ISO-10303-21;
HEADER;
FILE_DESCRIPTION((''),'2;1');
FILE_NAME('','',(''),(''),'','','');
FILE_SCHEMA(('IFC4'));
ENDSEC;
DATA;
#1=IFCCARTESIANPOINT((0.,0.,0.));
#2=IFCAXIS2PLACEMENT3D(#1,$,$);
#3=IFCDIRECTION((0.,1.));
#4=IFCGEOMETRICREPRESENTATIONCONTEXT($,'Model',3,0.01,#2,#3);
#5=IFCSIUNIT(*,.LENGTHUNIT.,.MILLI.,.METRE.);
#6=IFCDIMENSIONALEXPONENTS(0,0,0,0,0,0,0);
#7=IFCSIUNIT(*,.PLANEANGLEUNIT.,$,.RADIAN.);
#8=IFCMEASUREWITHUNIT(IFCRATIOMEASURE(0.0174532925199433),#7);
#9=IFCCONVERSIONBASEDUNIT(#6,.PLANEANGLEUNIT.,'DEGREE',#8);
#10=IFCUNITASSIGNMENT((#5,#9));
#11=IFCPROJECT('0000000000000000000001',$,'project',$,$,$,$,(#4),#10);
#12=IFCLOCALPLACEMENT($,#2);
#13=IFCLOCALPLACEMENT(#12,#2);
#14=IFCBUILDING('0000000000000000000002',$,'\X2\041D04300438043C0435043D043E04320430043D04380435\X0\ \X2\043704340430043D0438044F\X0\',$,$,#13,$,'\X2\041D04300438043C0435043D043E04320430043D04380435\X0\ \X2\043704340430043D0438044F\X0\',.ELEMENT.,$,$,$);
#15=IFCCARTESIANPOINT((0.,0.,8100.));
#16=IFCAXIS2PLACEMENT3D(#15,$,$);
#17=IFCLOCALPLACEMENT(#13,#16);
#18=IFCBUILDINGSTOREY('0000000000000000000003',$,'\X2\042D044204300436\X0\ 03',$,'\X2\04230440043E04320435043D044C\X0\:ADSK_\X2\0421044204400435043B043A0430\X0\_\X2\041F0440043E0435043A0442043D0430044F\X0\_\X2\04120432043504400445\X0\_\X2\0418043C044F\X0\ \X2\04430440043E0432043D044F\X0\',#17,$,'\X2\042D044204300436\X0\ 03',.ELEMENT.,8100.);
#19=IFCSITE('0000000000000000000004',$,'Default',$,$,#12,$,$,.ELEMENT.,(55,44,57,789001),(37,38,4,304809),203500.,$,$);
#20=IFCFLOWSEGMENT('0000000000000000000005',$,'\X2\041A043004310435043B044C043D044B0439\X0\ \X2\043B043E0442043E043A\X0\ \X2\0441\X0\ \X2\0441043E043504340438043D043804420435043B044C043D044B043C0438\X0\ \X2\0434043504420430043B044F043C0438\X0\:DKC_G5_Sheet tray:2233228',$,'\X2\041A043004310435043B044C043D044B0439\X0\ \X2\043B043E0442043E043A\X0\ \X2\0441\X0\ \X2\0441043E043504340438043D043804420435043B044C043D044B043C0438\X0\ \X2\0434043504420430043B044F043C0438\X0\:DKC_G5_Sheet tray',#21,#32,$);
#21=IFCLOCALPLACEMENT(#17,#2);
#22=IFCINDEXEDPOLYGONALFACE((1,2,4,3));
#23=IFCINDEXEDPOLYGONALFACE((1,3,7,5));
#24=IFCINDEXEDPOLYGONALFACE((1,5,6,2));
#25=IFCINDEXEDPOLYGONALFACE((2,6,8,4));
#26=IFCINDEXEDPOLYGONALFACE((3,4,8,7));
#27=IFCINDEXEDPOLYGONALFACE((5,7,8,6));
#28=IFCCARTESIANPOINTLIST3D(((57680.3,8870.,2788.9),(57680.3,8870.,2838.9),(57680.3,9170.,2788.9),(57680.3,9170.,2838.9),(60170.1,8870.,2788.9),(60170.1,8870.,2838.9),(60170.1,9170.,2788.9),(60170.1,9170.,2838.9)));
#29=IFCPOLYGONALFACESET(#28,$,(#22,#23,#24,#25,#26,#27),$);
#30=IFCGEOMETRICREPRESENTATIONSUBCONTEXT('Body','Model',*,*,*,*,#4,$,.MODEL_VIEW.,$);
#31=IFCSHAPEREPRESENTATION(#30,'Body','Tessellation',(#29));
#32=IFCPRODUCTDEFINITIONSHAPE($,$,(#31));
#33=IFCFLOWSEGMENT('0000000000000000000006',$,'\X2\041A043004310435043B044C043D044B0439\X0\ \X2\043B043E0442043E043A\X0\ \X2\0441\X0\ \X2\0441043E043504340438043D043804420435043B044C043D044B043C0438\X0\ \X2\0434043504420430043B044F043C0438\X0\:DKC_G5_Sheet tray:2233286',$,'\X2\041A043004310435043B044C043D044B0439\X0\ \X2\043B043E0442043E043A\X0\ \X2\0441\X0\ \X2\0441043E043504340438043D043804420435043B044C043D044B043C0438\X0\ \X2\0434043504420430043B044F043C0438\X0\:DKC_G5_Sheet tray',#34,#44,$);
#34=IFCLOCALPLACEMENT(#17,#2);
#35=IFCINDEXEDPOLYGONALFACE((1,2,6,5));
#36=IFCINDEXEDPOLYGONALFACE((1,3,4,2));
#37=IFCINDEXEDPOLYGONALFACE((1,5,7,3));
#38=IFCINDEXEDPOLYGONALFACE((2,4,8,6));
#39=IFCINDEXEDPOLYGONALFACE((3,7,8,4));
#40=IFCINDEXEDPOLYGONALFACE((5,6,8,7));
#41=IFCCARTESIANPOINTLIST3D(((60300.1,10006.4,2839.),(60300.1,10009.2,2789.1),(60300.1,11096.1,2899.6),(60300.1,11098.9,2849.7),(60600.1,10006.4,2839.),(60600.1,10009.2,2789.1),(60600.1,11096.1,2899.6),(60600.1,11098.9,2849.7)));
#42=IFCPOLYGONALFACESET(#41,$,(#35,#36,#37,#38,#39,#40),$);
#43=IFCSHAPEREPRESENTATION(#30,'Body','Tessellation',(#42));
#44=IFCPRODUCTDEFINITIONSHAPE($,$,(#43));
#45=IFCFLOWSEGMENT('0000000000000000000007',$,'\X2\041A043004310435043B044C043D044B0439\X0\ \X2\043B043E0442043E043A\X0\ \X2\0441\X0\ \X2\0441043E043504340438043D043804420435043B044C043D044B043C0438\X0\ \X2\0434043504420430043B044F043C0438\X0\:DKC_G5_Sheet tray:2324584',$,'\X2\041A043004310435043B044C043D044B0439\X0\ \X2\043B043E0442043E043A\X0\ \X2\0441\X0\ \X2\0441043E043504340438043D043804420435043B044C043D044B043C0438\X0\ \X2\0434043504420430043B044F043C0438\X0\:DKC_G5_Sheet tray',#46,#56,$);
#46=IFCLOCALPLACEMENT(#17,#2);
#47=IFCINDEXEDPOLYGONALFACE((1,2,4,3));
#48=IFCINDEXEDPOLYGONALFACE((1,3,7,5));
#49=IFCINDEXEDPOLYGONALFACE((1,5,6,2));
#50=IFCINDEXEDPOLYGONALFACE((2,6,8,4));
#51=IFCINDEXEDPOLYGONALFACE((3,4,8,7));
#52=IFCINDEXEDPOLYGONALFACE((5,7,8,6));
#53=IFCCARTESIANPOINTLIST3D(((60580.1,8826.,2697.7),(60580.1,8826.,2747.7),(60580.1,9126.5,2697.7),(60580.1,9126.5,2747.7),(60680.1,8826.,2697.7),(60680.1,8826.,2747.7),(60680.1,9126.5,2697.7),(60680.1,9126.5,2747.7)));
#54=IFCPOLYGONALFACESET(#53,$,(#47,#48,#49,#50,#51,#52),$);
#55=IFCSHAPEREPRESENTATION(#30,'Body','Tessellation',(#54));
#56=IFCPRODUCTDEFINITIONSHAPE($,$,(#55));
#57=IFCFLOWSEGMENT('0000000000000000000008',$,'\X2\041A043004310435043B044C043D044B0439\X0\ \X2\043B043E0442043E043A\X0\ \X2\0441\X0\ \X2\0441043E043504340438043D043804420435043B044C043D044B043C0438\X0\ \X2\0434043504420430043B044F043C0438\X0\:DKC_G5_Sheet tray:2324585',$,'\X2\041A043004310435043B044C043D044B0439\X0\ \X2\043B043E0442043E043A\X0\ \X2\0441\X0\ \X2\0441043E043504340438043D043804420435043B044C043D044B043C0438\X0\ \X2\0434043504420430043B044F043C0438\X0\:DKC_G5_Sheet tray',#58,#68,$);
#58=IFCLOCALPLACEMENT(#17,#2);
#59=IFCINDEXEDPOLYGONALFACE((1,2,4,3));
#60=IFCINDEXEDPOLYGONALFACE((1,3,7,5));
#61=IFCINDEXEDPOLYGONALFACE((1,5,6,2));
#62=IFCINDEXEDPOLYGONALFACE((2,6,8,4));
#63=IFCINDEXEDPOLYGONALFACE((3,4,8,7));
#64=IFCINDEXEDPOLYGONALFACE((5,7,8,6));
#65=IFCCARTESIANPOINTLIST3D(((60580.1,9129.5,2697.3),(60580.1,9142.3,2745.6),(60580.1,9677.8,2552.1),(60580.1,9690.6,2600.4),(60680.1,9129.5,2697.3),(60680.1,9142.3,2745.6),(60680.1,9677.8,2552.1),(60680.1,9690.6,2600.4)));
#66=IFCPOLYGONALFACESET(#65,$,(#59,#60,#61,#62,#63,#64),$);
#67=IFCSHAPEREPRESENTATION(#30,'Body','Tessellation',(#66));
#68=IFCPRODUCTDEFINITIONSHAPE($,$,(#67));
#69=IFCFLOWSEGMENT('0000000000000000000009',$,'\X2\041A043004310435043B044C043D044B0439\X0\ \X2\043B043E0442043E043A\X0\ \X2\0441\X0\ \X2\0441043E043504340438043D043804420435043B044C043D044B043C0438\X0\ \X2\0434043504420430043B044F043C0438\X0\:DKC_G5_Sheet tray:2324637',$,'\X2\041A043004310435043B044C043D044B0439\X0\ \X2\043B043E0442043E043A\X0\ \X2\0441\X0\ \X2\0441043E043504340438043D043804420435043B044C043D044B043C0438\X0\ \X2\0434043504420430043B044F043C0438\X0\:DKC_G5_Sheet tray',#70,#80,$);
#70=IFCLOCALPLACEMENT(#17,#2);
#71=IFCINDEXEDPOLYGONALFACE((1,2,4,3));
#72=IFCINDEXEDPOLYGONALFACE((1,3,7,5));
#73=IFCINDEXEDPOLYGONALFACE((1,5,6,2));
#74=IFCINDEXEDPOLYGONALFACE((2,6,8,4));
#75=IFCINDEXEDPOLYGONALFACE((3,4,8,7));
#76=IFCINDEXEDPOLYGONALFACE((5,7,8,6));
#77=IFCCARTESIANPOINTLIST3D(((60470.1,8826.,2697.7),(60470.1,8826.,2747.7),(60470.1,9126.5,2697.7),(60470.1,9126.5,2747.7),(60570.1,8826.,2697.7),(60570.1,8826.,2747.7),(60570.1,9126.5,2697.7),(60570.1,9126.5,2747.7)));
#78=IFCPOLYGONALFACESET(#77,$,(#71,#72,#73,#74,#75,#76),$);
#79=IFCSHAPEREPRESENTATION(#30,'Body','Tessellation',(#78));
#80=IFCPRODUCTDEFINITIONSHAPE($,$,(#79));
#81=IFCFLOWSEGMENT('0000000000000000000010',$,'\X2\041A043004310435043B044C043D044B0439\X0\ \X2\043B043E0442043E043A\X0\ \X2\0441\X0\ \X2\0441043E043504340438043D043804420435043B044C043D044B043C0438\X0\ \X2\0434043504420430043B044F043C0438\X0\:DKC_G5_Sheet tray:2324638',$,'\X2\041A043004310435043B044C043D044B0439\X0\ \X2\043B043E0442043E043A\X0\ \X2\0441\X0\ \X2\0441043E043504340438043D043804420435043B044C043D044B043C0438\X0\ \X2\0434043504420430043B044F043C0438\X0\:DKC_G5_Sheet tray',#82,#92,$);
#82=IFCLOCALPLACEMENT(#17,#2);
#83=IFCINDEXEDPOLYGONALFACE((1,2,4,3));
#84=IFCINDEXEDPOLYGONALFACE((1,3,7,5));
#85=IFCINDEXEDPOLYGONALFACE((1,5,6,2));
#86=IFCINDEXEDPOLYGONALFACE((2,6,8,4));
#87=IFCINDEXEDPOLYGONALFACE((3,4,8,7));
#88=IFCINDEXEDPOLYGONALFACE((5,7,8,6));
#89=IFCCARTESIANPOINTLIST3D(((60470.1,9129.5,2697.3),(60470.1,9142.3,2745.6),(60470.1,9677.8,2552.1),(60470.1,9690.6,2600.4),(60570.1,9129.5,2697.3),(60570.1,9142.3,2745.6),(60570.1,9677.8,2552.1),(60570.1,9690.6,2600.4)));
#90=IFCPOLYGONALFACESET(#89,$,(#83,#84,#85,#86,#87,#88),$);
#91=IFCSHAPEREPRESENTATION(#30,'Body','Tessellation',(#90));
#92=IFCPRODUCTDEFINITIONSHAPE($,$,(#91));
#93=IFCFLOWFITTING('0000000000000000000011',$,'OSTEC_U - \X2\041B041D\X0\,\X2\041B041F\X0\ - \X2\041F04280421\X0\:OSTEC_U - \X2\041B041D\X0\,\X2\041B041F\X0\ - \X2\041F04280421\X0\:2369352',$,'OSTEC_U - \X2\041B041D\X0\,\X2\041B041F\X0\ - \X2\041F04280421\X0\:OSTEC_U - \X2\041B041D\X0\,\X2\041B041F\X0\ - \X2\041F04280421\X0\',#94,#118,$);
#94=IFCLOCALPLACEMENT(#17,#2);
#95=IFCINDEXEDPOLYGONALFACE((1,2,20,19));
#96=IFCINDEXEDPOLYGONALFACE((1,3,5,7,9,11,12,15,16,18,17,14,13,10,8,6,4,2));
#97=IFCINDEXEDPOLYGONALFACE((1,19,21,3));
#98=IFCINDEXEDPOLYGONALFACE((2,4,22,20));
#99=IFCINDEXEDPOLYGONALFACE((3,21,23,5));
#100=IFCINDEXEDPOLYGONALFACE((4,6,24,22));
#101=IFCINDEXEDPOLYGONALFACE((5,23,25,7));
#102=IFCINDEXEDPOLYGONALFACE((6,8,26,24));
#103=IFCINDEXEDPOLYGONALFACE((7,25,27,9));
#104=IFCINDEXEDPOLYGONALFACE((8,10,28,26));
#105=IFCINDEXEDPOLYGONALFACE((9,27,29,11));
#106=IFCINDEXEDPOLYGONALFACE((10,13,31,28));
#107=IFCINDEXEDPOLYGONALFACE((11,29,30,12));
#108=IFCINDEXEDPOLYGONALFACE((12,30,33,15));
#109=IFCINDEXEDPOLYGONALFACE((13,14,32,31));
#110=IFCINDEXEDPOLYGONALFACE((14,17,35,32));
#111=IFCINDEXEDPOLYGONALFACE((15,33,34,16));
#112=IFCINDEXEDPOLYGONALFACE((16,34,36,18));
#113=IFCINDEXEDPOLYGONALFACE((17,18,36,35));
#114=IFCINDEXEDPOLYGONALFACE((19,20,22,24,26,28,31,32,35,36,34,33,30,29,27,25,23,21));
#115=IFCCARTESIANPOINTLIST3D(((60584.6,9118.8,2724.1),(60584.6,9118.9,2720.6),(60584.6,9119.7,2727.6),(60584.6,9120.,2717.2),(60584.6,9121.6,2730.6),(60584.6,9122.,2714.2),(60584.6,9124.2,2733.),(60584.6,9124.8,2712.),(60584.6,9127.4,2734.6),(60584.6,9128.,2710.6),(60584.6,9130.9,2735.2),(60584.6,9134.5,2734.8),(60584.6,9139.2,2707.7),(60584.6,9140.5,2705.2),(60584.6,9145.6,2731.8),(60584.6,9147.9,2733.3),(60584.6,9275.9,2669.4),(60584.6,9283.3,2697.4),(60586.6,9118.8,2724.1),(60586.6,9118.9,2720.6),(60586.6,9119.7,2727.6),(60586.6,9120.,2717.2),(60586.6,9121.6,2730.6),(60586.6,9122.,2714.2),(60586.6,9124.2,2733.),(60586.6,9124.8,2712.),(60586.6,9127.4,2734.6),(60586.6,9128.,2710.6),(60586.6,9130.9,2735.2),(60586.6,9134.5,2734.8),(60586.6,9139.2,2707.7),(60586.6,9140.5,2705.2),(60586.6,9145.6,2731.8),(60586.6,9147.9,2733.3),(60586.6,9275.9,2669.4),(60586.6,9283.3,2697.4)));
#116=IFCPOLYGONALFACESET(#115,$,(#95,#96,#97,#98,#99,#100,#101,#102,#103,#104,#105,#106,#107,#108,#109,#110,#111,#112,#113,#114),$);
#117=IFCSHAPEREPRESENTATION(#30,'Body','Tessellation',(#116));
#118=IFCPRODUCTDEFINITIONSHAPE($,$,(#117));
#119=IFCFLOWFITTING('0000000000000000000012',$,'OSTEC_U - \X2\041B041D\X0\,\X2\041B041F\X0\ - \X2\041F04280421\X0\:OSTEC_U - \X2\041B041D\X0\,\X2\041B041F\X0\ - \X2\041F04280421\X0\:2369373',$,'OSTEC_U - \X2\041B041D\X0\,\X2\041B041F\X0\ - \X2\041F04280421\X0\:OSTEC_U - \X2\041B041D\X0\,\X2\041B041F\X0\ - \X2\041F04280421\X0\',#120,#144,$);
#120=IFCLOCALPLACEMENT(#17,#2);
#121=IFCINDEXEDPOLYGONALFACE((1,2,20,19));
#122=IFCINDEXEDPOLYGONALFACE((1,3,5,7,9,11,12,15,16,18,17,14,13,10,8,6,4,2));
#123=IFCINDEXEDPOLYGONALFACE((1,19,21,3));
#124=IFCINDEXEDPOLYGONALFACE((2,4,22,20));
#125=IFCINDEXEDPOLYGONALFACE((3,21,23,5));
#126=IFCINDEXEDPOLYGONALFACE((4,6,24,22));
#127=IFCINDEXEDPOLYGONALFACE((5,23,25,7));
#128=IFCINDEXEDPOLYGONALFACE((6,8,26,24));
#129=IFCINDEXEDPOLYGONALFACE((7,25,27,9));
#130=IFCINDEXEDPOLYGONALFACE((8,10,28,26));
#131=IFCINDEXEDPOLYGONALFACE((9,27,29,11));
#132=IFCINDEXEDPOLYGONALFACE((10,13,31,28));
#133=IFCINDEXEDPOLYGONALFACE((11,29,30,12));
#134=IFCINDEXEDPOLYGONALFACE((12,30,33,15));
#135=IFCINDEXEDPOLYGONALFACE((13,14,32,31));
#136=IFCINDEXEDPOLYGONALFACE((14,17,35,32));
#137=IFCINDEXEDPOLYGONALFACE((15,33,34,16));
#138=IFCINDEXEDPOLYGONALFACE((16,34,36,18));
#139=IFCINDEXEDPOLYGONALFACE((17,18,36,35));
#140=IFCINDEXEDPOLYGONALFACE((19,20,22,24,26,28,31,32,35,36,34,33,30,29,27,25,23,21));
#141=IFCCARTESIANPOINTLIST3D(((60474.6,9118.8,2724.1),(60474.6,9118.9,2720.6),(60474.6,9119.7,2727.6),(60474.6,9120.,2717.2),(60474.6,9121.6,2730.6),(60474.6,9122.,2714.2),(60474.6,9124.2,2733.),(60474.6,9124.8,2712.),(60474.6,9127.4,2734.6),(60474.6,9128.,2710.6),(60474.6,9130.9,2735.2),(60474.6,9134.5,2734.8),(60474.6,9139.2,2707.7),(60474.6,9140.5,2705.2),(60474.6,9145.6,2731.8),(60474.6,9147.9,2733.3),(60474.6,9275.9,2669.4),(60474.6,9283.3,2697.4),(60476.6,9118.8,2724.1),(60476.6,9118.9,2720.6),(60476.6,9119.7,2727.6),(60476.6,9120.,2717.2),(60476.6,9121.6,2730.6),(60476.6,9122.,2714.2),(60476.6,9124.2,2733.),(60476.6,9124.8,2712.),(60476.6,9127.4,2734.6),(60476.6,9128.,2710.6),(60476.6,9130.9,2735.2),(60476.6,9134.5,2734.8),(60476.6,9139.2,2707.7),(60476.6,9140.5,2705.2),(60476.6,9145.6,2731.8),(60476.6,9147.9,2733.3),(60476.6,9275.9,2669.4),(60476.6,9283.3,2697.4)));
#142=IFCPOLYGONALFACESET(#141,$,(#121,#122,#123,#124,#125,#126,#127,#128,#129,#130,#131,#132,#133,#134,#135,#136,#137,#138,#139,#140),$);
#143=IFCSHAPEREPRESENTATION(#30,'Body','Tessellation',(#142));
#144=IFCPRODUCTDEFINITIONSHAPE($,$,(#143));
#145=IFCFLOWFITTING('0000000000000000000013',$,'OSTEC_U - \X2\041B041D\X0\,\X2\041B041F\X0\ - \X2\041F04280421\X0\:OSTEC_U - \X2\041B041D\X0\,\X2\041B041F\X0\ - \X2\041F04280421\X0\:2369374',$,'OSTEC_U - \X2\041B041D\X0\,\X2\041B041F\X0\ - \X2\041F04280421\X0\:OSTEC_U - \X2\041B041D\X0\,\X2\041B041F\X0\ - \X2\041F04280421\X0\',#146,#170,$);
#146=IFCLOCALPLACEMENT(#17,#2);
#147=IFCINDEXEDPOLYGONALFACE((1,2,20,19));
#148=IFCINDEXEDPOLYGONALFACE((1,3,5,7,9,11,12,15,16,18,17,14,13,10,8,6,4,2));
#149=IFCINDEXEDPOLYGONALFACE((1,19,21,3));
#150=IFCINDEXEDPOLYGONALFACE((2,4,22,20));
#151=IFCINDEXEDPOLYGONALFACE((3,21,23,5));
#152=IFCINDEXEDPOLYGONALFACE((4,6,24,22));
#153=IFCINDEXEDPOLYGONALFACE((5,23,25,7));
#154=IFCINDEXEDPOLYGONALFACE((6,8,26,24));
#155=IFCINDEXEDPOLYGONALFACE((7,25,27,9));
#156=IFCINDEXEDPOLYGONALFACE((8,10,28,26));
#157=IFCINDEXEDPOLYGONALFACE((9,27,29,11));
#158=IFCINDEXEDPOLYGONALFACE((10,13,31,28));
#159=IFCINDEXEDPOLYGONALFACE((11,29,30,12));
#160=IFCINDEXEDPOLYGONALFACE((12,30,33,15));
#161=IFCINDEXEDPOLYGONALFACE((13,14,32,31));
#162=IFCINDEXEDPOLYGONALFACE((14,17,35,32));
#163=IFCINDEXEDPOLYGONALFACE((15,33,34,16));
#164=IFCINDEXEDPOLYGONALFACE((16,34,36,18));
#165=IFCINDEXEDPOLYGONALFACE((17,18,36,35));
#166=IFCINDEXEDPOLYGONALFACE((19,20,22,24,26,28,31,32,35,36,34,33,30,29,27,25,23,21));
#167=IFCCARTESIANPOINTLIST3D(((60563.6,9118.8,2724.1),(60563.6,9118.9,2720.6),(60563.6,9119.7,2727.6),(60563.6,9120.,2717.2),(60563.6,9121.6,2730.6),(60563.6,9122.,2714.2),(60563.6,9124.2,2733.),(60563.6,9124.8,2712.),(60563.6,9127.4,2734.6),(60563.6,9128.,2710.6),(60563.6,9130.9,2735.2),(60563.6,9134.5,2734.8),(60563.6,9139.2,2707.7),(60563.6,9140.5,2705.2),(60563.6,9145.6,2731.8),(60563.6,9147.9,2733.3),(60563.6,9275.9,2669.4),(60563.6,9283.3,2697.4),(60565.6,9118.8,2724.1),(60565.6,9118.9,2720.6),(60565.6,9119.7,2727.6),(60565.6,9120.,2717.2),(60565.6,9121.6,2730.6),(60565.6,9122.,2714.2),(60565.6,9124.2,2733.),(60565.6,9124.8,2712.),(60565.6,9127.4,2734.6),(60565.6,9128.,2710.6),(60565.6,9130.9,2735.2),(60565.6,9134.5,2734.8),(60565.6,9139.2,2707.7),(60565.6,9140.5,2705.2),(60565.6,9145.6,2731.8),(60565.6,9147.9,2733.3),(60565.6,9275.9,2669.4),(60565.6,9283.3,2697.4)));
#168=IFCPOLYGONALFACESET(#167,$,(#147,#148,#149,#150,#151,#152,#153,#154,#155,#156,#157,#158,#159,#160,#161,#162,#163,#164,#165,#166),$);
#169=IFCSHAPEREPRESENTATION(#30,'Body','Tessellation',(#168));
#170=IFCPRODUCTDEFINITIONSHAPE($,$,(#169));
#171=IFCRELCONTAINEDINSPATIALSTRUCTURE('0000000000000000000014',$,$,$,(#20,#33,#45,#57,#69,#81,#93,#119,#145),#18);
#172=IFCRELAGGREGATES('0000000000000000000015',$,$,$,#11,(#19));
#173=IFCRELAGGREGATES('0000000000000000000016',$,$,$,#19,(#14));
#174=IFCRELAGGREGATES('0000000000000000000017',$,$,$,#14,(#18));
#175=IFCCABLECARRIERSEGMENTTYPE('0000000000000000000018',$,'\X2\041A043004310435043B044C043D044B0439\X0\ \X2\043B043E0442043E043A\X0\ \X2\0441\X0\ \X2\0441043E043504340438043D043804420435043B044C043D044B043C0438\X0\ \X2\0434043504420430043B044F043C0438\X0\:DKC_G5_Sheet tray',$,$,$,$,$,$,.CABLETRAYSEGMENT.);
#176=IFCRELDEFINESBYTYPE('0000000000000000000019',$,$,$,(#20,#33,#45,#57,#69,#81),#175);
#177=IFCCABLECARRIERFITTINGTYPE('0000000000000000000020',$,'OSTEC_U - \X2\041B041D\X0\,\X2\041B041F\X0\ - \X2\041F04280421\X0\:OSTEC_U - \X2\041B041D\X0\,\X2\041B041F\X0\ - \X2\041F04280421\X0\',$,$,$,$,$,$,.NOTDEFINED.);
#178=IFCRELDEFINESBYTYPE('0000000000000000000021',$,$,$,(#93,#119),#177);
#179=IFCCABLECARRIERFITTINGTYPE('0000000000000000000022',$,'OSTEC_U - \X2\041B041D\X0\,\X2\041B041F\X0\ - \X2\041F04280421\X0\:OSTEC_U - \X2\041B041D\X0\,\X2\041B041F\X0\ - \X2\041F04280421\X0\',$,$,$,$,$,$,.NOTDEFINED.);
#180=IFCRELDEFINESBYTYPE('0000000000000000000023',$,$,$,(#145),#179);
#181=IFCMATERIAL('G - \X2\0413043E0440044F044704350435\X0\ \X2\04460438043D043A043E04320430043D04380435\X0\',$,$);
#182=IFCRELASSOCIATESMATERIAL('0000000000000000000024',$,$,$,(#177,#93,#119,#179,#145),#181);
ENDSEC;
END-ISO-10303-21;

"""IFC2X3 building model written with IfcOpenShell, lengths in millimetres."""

from ifc_helpers import new_model, entity, si_unit, converted_unit, direction, frame, frame_2d, origin, origin_2d_with_axis, place, context, subcontext, project, spatial, polyline, circle_curve, parameter, trimmed, segment, composite_curve, rectangle, outline, extrude, source, transform, mapped, material, type_object, type_shapes, element, save


model = new_model("IFC2X3")

# Units and contexts
model_context = context("Model", 3, precision=0.01, world=origin(), true_north=direction((0.0, 1.0)))
body_context = subcontext(model_context, "Body", "Model", "MODEL_VIEW")
ifc_project = project(units=[si_unit("LENGTHUNIT", "METRE", prefix="MILLI"), converted_unit("PLANEANGLEUNIT", "DEGREE", entity("IfcRatioMeasure", 0.0174532925199433), si_unit("PLANEANGLEUNIT", "RADIAN"), dimensions=[0, 0, 0, 0, 0, 0, 0])], contexts=[model_context])

# Site, building, storey
site_placement = place(None, origin())
site = spatial("IfcSite", under=ifc_project, at=site_placement, Name="Default", CompositionType="ELEMENT", RefLatitude=(55, 44, 57, 789001), RefLongitude=(37, 38, 4, 304809), RefElevation=203500.0)
building_placement = place(site_placement, origin())
building = spatial("IfcBuilding", under=site, at=building_placement, Name="Наименование здания", LongName="Наименование здания", CompositionType="ELEMENT")
storey_placement = place(building_placement, frame((0.0, 0.0, 8100.0)))
storey = spatial("IfcBuildingStorey", under=building, at=storey_placement, Name="Этаж 03", ObjectType="Уровень:ADSK_Стрелка_Проектная_Вверх_Имя уровня", LongName="Этаж 03", CompositionType="ELEMENT", Elevation=8100.0)

# Flow segments
cable_carrier_segment_type = type_object("IfcCableCarrierSegmentType", Name="Кабельный лоток с соединительными деталями:DKC_G5_Sheet tray", PredefinedType="CABLETRAYSEGMENT")
flow_segment_1_placement = place(storey_placement, frame((57680.2, 8870.0, 2788.9)))
element("IfcFlowSegment", 1, at=flow_segment_1_placement, inside=storey, type_object=cable_carrier_segment_type, Name="Кабельный лоток с соединительными деталями:DKC_G5_Sheet tray:2233228", ObjectType="Кабельный лоток с соединительными деталями:DKC_G5_Sheet tray", context=body_context, shape_type="SweptSolid", body=[
    extrude(rectangle(XDim=2489.9, YDim=300.0, at=origin_2d_with_axis()), frame((1244.9, 150.0, 0.0)), (0.0, 0.0, 1.0), 50.0),
])
flow_segment_2_placement = place(storey_placement, frame((60300.1, 10006.4, 2789.1)))
element("IfcFlowSegment", 2, at=flow_segment_2_placement, inside=storey, type_object=cable_carrier_segment_type, Name="Кабельный лоток с соединительными деталями:DKC_G5_Sheet tray:2233286", ObjectType="Кабельный лоток с соединительными деталями:DKC_G5_Sheet tray", context=body_context, shape_type="SweptSolid", body=[
    extrude(rectangle(XDim=50.0, YDim=1091.4, at=frame_2d((0.0, 0.0), x_axis=(0.0, 1.0))), frame((0.0, 546.2, 55.3), z_axis=(1.0, 0.0, 0.0), x_axis=(0.0, -0.998458, -0.055513)), (0.0, 0.0, 1.0), 300.0),
])
flow_segment_3_placement = place(storey_placement, frame((60580.1, 8826.0, 2697.7)))
element("IfcFlowSegment", 3, at=flow_segment_3_placement, inside=storey, type_object=cable_carrier_segment_type, Name="Кабельный лоток с соединительными деталями:DKC_G5_Sheet tray:2324584", ObjectType="Кабельный лоток с соединительными деталями:DKC_G5_Sheet tray", context=body_context, shape_type="SweptSolid", body=[
    extrude(rectangle(XDim=300.4, YDim=100.0, at=origin_2d_with_axis()), frame((50.0, 150.2, 0.0), z_axis=(0.0, 0.0, 1.0), x_axis=(0.0, -1.0, 0.0)), (0.0, 0.0, 1.0), 50.0),
])
flow_segment_4_placement = place(storey_placement, frame((60580.1, 9129.5, 2552.1)))
element("IfcFlowSegment", 4, at=flow_segment_4_placement, inside=storey, type_object=cable_carrier_segment_type, Name="Кабельный лоток с соединительными деталями:DKC_G5_Sheet tray:2324585", ObjectType="Кабельный лоток с соединительными деталями:DKC_G5_Sheet tray", context=body_context, shape_type="SweptSolid", body=[
    extrude(rectangle(XDim=50.0, YDim=567.3, at=frame_2d((0.0, 0.0), x_axis=(0.0, 1.0))), frame((0.0, 280.6, 96.8), z_axis=(1.0, 0.0, 0.0), x_axis=(0.0, 0.966668, -0.256034)), (0.0, 0.0, 1.0), 100.0),
])
flow_segment_5_placement = place(storey_placement, frame((60470.1, 8826.0, 2697.7)))
element("IfcFlowSegment", 5, at=flow_segment_5_placement, inside=storey, type_object=cable_carrier_segment_type, Name="Кабельный лоток с соединительными деталями:DKC_G5_Sheet tray:2324637", ObjectType="Кабельный лоток с соединительными деталями:DKC_G5_Sheet tray", context=body_context, shape_type="SweptSolid", body=[
    extrude(rectangle(XDim=300.4, YDim=100.0, at=origin_2d_with_axis()), frame((50.0, 150.2, 0.0), z_axis=(0.0, 0.0, 1.0), x_axis=(0.0, -1.0, 0.0)), (0.0, 0.0, 1.0), 50.0),
])
flow_segment_6_placement = place(storey_placement, frame((60470.1, 9129.5, 2552.1)))
element("IfcFlowSegment", 6, at=flow_segment_6_placement, inside=storey, type_object=cable_carrier_segment_type, Name="Кабельный лоток с соединительными деталями:DKC_G5_Sheet tray:2324638", ObjectType="Кабельный лоток с соединительными деталями:DKC_G5_Sheet tray", context=body_context, shape_type="SweptSolid", body=[
    extrude(rectangle(XDim=50.0, YDim=567.3, at=frame_2d((0.0, 0.0), x_axis=(0.0, 1.0))), frame((0.0, 280.6, 96.8), z_axis=(1.0, 0.0, 0.0), x_axis=(0.0, 0.966668, -0.256034)), (0.0, 0.0, 1.0), 100.0),
])

# Flow fittings
ifc_material = material(Name="G - Горячее цинкование")
cable_carrier_fitting_type_1 = type_object("IfcCableCarrierFittingType", Name="OSTEC_U - ЛН,ЛП - ПШС:OSTEC_U - ЛН,ЛП - ПШС", PredefinedType="NOTDEFINED", material=ifc_material)
shared_shape_1 = source(origin(), body_context, "Body", "SweptSolid", [
    extrude(outline(composite_curve([segment(trimmed(circle_curve(frame_2d((-44.6, 0.0), x_axis=(1.0, 0.0)), 12.5), [parameter(90.0)], [parameter(270.0)], True, "PARAMETER"), True, "CONTINUOUS"), segment(polyline([(-44.6, -12.5), (-33.1, -12.5)]), True, "CONTINUOUS"), segment(polyline([(-33.1, -12.5), (-31.2, -14.5)]), True, "CONTINUOUS"), segment(polyline([(-31.2, -14.5), (108.9, -14.5)]), True, "CONTINUOUS"), segment(polyline([(108.9, -14.5), (108.9, 14.5)]), True, "CONTINUOUS"), segment(polyline([(108.9, 14.5), (-31.2, 14.5)]), True, "CONTINUOUS"), segment(polyline([(-31.2, 14.5), (-33.1, 12.5)]), True, "CONTINUOUS"), segment(polyline([(-33.1, 12.5), (-44.6, 12.5)]), True, "CONTINUOUS")], self_intersect=False)), frame((44.6, 0.0, 0.0), z_axis=(0.0, 0.0, -1.0), x_axis=(1.0, 0.0, 0.0)), (0.0, 0.0, -1.0), 2.0),
])
type_shapes(cable_carrier_fitting_type_1, [shared_shape_1])
flow_fitting_1_placement = place(storey_placement, frame((60586.7, 9131.2, 2722.7), z_axis=(-1.0, 0.0, 0.0), x_axis=(0.0, 0.966668, -0.256034)))
element("IfcFlowFitting", 7, at=flow_fitting_1_placement, inside=storey, type_object=cable_carrier_fitting_type_1, material=ifc_material, Name="OSTEC_U - ЛН,ЛП - ПШС:OSTEC_U - ЛН,ЛП - ПШС:2369352", ObjectType="OSTEC_U - ЛН,ЛП - ПШС:OSTEC_U - ЛН,ЛП - ПШС", context=body_context, shape_type="MappedRepresentation", body=[
    mapped(shared_shape_1, transform((0.0, 0.0, 0.0), scale=1.0)),
])
flow_fitting_2_placement = place(storey_placement, frame((60476.7, 9131.2, 2722.7), z_axis=(-1.0, 0.0, 0.0), x_axis=(0.0, 0.966668, -0.256034)))
element("IfcFlowFitting", 8, at=flow_fitting_2_placement, inside=storey, type_object=cable_carrier_fitting_type_1, material=ifc_material, Name="OSTEC_U - ЛН,ЛП - ПШС:OSTEC_U - ЛН,ЛП - ПШС:2369373", ObjectType="OSTEC_U - ЛН,ЛП - ПШС:OSTEC_U - ЛН,ЛП - ПШС", context=body_context, shape_type="MappedRepresentation", body=[
    mapped(shared_shape_1, transform((0.0, 0.0, 0.0), scale=1.0)),
])
shared_shape_2 = source(origin(), body_context, "Body", "SweptSolid", [
    extrude(outline(composite_curve([segment(trimmed(circle_curve(frame_2d((-44.6, 0.0), x_axis=(1.0, 0.0)), 12.5), [parameter(90.0)], [parameter(270.0)], True, "PARAMETER"), True, "CONTINUOUS"), segment(polyline([(-44.6, -12.5), (-33.1, -12.5)]), True, "CONTINUOUS"), segment(polyline([(-33.1, -12.5), (-31.2, -14.5)]), True, "CONTINUOUS"), segment(polyline([(-31.2, -14.5), (108.9, -14.5)]), True, "CONTINUOUS"), segment(polyline([(108.9, -14.5), (108.9, 14.5)]), True, "CONTINUOUS"), segment(polyline([(108.9, 14.5), (-31.2, 14.5)]), True, "CONTINUOUS"), segment(polyline([(-31.2, 14.5), (-33.1, 12.5)]), True, "CONTINUOUS"), segment(polyline([(-33.1, 12.5), (-44.6, 12.5)]), True, "CONTINUOUS")], self_intersect=False)), frame((44.6, 0.0, 0.0)), (0.0, 0.0, 1.0), 2.0),
])
cable_carrier_fitting_type_2 = type_object("IfcCableCarrierFittingType", Name="OSTEC_U - ЛН,ЛП - ПШС:OSTEC_U - ЛН,ЛП - ПШС", PredefinedType="NOTDEFINED", material=ifc_material)
type_shapes(cable_carrier_fitting_type_2, [shared_shape_2])
flow_fitting_3_placement = place(storey_placement, frame((60563.6, 9131.2, 2722.7), z_axis=(1.0, 0.0, 0.0), x_axis=(0.0, 0.966668, -0.256034)))
element("IfcFlowFitting", 9, at=flow_fitting_3_placement, inside=storey, type_object=cable_carrier_fitting_type_2, material=ifc_material, Name="OSTEC_U - ЛН,ЛП - ПШС:OSTEC_U - ЛН,ЛП - ПШС:2369374", ObjectType="OSTEC_U - ЛН,ЛП - ПШС:OSTEC_U - ЛН,ЛП - ПШС", context=body_context, shape_type="MappedRepresentation", body=[
    mapped(shared_shape_2, transform((0.0, 0.0, 0.0), scale=1.0)),
])

save(model, "model.ifc")
